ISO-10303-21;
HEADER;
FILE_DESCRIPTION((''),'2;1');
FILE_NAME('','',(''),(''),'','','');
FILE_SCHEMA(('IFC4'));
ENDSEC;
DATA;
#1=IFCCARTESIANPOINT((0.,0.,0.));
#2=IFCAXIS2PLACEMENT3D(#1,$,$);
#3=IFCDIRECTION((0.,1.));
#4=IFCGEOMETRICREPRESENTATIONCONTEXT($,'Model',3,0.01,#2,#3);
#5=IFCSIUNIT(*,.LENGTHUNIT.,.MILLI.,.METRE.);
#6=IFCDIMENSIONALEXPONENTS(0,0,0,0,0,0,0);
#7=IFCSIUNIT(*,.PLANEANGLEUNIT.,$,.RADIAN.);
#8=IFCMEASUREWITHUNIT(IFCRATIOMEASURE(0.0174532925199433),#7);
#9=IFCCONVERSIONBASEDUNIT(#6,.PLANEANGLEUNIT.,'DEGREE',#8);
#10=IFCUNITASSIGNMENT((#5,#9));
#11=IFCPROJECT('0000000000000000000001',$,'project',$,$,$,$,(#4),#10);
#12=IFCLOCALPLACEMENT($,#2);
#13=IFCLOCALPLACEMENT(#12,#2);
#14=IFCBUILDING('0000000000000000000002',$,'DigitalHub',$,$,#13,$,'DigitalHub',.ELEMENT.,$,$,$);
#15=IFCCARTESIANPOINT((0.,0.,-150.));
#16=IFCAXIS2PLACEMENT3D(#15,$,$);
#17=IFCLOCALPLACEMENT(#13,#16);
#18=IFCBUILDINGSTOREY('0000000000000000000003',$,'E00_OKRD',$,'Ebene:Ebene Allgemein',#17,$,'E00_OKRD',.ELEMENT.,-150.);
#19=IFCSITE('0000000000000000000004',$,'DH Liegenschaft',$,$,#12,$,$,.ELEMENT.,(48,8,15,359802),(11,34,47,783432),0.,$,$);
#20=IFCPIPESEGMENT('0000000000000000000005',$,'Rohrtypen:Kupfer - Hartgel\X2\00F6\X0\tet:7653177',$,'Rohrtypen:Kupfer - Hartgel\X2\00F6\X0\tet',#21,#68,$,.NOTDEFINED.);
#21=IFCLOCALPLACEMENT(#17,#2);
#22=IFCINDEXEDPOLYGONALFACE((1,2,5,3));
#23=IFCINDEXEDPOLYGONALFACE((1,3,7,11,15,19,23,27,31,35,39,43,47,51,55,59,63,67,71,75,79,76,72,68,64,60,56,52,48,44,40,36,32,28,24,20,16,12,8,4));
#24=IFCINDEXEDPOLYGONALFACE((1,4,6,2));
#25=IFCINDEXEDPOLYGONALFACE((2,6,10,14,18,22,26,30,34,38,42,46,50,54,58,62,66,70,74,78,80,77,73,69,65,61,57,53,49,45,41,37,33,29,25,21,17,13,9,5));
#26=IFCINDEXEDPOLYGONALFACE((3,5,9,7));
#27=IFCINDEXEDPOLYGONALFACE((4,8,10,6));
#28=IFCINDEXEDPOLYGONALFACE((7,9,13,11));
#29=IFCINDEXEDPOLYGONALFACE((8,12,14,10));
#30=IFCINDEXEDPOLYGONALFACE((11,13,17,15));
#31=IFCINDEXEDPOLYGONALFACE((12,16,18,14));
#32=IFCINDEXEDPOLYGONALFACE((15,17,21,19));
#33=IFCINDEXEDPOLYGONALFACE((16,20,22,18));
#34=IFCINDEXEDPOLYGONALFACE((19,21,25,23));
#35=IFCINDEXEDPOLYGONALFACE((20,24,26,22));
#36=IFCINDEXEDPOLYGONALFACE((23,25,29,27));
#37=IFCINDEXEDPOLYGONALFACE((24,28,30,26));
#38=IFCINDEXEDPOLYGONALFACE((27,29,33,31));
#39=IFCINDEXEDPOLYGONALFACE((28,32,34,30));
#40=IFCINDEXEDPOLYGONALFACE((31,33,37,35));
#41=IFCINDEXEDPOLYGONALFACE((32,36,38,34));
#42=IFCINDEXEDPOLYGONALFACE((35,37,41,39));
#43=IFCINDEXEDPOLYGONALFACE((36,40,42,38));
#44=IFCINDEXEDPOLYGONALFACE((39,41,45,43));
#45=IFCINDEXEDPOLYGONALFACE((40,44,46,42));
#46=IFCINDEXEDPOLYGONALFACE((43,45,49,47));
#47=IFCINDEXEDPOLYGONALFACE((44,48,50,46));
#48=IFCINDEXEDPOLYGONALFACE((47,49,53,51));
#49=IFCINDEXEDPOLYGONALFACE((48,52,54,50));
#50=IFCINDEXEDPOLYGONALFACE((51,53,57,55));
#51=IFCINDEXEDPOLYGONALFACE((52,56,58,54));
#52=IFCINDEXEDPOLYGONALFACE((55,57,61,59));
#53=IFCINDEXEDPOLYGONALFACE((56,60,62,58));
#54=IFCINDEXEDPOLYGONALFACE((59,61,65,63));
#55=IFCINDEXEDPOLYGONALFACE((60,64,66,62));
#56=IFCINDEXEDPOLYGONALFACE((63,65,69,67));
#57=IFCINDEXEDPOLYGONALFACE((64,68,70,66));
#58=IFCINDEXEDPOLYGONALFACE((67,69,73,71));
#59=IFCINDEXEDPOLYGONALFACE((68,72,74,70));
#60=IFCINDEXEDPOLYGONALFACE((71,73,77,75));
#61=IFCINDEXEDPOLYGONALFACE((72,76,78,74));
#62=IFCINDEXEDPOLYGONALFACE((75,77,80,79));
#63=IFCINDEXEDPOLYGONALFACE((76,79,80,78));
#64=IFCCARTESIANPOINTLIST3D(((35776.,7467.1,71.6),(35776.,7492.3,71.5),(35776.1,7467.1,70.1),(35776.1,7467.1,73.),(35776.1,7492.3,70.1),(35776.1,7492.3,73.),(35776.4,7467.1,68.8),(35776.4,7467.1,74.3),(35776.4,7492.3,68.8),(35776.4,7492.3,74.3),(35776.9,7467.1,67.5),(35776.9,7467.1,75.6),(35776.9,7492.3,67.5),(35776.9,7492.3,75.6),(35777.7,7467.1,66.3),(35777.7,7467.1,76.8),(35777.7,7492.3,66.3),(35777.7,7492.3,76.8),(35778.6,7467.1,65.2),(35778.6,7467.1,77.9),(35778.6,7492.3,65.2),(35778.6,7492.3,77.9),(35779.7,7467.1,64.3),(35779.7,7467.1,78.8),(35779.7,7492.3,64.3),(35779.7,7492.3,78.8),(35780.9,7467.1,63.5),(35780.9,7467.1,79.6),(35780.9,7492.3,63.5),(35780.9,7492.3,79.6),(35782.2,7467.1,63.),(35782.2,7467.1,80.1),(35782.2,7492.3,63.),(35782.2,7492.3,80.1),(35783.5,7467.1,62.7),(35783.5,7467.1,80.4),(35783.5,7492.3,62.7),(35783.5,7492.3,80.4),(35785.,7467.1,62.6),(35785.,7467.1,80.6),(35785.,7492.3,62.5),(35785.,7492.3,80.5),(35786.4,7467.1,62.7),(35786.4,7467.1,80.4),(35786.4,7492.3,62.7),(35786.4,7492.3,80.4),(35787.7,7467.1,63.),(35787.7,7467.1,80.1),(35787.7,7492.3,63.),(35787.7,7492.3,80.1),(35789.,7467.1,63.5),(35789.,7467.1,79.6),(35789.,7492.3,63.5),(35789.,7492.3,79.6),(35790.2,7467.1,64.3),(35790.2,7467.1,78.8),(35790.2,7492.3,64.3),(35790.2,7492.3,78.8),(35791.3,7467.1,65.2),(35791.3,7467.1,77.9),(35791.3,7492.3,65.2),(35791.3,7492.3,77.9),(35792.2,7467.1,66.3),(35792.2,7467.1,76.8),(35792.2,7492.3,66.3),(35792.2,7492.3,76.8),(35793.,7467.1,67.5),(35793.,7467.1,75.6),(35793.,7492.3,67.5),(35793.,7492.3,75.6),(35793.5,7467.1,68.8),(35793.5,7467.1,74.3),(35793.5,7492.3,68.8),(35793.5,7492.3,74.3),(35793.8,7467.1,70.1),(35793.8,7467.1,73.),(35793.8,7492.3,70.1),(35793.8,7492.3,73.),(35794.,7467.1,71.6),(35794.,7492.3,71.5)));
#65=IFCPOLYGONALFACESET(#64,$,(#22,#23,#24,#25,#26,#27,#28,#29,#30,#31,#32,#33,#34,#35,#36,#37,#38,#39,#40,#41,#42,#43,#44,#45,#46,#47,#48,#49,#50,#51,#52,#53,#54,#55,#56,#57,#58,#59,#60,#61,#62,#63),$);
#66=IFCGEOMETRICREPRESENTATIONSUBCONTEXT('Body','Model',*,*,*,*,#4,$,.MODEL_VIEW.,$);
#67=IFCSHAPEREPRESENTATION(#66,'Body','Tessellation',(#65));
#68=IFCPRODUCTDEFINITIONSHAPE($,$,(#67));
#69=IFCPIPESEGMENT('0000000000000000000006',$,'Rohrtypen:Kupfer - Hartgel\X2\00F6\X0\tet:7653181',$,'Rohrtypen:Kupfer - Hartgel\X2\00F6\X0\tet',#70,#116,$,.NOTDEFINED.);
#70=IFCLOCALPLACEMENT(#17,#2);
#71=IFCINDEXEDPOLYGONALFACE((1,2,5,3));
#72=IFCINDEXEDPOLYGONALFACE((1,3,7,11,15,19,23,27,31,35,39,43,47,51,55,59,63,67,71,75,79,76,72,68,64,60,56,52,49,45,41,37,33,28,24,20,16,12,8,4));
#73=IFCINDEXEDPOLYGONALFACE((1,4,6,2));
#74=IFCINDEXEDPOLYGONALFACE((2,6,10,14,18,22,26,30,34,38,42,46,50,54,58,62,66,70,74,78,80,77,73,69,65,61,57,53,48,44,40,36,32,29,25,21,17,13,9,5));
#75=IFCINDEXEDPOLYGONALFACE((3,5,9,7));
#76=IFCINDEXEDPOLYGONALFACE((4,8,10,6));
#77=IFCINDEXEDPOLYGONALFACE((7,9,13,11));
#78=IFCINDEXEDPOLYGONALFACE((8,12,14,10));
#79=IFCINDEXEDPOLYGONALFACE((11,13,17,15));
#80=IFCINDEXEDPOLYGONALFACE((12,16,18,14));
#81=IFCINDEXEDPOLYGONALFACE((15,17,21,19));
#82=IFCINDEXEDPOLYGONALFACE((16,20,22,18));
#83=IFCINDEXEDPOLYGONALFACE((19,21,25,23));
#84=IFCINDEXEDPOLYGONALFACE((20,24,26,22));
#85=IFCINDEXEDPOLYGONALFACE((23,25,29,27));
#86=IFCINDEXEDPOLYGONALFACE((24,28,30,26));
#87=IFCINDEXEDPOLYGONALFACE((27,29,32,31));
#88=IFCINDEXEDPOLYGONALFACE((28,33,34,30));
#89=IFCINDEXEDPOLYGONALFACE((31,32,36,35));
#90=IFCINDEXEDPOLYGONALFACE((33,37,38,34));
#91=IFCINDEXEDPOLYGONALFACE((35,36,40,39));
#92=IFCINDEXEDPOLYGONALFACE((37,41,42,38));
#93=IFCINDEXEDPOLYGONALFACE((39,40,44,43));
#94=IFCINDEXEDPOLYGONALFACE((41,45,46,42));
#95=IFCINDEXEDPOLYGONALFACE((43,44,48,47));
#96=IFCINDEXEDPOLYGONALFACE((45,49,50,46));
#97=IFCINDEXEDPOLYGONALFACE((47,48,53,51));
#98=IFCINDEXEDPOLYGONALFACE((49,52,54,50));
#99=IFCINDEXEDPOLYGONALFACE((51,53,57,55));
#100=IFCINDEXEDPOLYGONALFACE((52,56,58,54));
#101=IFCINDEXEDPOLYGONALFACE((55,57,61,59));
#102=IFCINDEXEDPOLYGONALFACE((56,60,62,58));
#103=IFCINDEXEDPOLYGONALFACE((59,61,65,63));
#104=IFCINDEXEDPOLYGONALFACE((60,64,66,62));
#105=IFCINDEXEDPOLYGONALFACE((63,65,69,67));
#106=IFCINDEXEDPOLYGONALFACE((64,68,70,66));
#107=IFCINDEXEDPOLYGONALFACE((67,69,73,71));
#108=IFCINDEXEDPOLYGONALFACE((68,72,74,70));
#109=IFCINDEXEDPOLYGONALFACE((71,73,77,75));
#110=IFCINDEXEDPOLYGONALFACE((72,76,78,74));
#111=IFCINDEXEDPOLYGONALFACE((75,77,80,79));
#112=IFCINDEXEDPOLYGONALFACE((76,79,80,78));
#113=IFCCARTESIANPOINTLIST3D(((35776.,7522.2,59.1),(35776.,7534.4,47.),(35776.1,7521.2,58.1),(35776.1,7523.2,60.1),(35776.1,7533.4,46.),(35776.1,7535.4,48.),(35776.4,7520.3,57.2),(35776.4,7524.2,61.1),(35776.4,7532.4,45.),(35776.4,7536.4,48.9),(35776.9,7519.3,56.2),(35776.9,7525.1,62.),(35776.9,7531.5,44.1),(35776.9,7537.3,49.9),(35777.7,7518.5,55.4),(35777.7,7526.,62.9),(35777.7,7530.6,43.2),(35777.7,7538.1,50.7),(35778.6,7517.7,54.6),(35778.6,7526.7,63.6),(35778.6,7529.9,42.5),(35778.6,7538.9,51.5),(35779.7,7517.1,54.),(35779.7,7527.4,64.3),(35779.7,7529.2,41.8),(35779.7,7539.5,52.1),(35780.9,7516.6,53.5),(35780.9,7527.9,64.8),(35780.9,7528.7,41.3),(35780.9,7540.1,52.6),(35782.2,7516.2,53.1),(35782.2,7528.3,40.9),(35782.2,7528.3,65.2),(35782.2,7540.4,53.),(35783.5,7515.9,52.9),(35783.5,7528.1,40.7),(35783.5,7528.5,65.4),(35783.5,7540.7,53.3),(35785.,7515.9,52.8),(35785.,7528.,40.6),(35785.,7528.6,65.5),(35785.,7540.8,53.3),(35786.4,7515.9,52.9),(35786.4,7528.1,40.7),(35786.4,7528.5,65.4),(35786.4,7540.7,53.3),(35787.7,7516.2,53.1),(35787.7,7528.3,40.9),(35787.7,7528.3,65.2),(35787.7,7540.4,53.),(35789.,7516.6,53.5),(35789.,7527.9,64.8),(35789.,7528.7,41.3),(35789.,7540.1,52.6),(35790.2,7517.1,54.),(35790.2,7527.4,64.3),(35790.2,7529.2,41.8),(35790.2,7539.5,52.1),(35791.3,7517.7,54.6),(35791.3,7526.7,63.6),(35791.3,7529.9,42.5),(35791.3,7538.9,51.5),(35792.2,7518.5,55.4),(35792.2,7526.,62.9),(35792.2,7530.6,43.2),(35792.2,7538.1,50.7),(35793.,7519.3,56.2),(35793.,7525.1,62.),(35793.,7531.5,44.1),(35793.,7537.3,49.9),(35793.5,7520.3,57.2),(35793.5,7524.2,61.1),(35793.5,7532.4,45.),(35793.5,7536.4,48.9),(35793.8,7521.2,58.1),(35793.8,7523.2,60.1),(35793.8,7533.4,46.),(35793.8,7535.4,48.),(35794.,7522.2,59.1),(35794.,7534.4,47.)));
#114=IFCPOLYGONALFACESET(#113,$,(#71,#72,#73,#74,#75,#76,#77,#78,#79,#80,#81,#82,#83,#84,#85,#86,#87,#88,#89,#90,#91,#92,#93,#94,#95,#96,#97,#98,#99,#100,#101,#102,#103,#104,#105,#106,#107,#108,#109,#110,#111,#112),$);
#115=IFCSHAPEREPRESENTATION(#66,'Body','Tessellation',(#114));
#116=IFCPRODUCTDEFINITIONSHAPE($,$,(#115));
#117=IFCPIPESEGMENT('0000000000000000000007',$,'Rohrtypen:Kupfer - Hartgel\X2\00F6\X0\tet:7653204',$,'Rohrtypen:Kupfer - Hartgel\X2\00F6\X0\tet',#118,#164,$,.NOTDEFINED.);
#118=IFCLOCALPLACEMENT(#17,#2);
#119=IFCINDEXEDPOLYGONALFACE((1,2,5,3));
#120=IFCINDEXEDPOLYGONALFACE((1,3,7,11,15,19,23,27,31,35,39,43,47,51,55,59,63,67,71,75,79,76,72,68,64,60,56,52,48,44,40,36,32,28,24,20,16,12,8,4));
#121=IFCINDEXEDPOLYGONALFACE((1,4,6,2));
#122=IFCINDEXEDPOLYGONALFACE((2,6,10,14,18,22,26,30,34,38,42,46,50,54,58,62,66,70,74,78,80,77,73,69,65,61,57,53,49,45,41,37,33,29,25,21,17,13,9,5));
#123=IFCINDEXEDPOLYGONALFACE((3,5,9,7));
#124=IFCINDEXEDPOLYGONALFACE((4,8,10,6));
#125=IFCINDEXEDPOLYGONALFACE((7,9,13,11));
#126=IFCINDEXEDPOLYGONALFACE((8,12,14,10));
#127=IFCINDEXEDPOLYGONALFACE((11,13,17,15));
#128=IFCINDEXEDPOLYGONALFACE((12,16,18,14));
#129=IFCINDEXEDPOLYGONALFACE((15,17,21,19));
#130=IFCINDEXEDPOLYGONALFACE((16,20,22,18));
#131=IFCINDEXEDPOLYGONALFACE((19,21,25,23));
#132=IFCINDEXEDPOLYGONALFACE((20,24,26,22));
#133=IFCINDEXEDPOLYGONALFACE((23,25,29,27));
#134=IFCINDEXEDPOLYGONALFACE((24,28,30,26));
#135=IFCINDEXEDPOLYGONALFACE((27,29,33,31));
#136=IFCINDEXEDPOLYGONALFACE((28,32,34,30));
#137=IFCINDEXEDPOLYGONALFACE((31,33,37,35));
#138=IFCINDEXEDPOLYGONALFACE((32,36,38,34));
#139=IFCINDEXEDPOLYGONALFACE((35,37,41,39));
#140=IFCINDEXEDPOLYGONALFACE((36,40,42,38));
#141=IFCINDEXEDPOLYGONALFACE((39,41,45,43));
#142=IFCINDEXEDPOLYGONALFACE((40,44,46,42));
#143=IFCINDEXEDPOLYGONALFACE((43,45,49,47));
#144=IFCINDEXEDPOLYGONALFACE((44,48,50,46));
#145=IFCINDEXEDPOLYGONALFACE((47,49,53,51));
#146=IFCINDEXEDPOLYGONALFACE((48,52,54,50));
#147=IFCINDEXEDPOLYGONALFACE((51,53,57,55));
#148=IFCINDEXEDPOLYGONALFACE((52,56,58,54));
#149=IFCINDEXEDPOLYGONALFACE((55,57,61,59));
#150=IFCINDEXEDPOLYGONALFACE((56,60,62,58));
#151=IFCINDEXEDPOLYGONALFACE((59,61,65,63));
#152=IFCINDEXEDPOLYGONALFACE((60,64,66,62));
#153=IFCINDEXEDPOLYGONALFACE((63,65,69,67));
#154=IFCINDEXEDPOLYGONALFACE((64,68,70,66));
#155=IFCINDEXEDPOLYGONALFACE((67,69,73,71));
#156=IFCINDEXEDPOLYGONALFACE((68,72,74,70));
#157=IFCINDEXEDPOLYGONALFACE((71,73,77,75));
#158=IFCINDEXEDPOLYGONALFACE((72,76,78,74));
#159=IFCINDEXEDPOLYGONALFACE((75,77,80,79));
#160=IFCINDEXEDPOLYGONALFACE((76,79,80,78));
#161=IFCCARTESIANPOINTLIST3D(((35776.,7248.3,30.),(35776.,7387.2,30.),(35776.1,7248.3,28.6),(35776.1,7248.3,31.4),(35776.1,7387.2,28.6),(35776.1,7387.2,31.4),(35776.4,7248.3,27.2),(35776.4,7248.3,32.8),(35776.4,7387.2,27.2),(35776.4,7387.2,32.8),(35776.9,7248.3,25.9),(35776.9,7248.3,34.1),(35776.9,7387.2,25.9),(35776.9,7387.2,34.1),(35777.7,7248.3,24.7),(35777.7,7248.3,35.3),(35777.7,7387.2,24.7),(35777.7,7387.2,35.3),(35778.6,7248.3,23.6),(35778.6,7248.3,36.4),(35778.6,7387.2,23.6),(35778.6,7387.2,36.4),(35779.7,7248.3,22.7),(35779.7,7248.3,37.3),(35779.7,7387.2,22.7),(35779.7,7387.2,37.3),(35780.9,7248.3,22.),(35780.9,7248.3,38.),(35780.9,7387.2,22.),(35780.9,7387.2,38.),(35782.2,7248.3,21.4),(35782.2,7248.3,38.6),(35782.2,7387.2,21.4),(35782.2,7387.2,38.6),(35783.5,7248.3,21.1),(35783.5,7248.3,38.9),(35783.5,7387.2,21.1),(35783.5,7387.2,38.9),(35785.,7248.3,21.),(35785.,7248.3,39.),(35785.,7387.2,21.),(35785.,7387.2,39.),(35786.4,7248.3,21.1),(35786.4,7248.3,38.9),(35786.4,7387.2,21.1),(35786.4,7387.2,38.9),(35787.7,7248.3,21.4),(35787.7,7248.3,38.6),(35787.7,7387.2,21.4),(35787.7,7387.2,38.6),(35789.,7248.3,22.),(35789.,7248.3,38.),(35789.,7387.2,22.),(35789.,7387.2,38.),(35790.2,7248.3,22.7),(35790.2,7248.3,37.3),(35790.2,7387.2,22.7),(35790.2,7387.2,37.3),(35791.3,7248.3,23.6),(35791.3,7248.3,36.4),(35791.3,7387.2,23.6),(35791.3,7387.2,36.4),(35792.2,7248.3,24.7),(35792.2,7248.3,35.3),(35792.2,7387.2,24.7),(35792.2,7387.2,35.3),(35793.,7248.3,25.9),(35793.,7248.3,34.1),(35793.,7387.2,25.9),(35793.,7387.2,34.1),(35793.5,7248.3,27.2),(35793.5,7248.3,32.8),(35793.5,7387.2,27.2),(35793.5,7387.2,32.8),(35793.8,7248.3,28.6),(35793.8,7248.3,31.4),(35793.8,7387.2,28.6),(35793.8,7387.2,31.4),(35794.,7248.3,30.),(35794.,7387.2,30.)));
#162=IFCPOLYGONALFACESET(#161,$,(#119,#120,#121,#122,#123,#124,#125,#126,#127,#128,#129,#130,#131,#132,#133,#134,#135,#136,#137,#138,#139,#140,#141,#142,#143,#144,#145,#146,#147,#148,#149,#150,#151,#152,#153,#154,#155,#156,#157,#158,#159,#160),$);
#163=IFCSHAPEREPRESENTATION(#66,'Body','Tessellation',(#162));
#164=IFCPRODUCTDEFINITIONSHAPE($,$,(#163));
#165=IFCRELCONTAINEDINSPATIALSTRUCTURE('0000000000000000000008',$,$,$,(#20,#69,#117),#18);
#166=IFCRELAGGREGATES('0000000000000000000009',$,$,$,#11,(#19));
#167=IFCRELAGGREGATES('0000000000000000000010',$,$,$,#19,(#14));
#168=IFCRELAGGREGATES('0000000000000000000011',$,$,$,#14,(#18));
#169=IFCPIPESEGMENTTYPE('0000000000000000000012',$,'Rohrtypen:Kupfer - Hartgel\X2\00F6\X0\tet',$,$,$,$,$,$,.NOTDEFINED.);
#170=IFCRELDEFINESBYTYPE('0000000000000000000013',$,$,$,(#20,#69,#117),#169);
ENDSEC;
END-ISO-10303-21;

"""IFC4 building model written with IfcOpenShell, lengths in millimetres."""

from ifc_helpers import new_model, entity, si_unit, converted_unit, direction, frame, origin, place, context, subcontext, project, spatial, indexed_curve, outline, extrude, type_object, element, save


model = new_model("IFC4")

# Units and contexts
model_context = context("Model", 3, precision=0.01, world=origin(), true_north=direction((0.0, 1.0)))
body_context = subcontext(model_context, "Body", "Model", "MODEL_VIEW")
ifc_project = project(units=[si_unit("LENGTHUNIT", "METRE", prefix="MILLI"), converted_unit("PLANEANGLEUNIT", "DEGREE", entity("IfcRatioMeasure", 0.0174532925199433), si_unit("PLANEANGLEUNIT", "RADIAN"), dimensions=[0, 0, 0, 0, 0, 0, 0])], contexts=[model_context])

# Site, building, storey
site_placement = place(None, origin())
site = spatial("IfcSite", under=ifc_project, at=site_placement, Name="DH Liegenschaft", CompositionType="ELEMENT", RefLatitude=(48, 8, 15, 359802), RefLongitude=(11, 34, 47, 783432), RefElevation=0.0)
building_placement = place(site_placement, origin())
building = spatial("IfcBuilding", under=site, at=building_placement, Name="DigitalHub", LongName="DigitalHub", CompositionType="ELEMENT")
storey_placement = place(building_placement, frame((0.0, 0.0, -150.0)))
storey = spatial("IfcBuildingStorey", under=building, at=storey_placement, Name="E00_OKRD", ObjectType="Ebene:Ebene Allgemein", LongName="E00_OKRD", CompositionType="ELEMENT", Elevation=-150.0)

# Pipe segments
pipe_segment_type = type_object("IfcPipeSegmentType", Name="Rohrtypen:Kupfer - Hartgelötet", PredefinedType="NOTDEFINED")
pipe_segment_1_placement = place(storey_placement, frame((35774.4, 7467.1, 61.0)))
element("IfcPipeSegment", 1, at=pipe_segment_1_placement, inside=storey, type_object=pipe_segment_type, Name="Rohrtypen:Kupfer - Hartgelötet:7653177", ObjectType="Rohrtypen:Kupfer - Hartgelötet", PredefinedType="NOTDEFINED", context=body_context, shape_type="SweptSolid", body=[
    extrude(outline(indexed_curve([(9.0, 0.0), (8.9, 1.4), (8.6, 2.8), (8.0, 4.1), (7.3, 5.3), (6.4, 6.4), (5.3, 7.3), (4.1, 8.0), (2.8, 8.6), (1.4, 8.9), (0.0, 9.0), (-1.4, 8.9), (-2.8, 8.6), (-4.1, 8.0), (-5.3, 7.3), (-6.4, 6.4), (-7.3, 5.3), (-8.0, 4.1), (-8.6, 2.8), (-8.9, 1.4), (-9.0, 0.0), (-8.9, -1.4), (-8.6, -2.8), (-8.0, -4.1), (-7.3, -5.3), (-6.4, -6.4), (-5.3, -7.3), (-4.1, -8.0), (-2.8, -8.6), (-1.4, -8.9), (0.0, -9.0), (1.4, -8.9), (2.8, -8.6), (4.1, -8.0), (5.3, -7.3), (6.4, -6.4), (7.3, -5.3), (8.0, -4.1), (8.6, -2.8), (8.9, -1.4), (9.0, 0.0)], self_intersect=False)), frame((10.6, 0.0, 10.6), z_axis=(0.000069, 1.0, -0.000282), x_axis=(-1.0, 0.000069, 0.0)), (0.0, 0.0, 1.0), 25.1),
])
pipe_segment_2_placement = place(storey_placement, frame((35774.4, 7514.3, 39.0)))
element("IfcPipeSegment", 2, at=pipe_segment_2_placement, inside=storey, type_object=pipe_segment_type, Name="Rohrtypen:Kupfer - Hartgelötet:7653181", ObjectType="Rohrtypen:Kupfer - Hartgelötet", PredefinedType="NOTDEFINED", context=body_context, shape_type="SweptSolid", body=[
    extrude(outline(indexed_curve([(9.0, 0.0), (8.9, 1.4), (8.6, 2.8), (8.0, 4.1), (7.3, 5.3), (6.4, 6.4), (5.3, 7.3), (4.1, 8.0), (2.8, 8.6), (1.4, 8.9), (0.0, 9.0), (-1.4, 8.9), (-2.8, 8.6), (-4.1, 8.0), (-5.3, 7.3), (-6.4, 6.4), (-7.3, 5.3), (-8.0, 4.1), (-8.6, 2.8), (-8.9, 1.4), (-9.0, 0.0), (-8.9, -1.4), (-8.6, -2.8), (-8.0, -4.1), (-7.3, -5.3), (-6.4, -6.4), (-5.3, -7.3), (-4.1, -8.0), (-2.8, -8.6), (-1.4, -8.9), (0.0, -9.0), (1.4, -8.9), (2.8, -8.6), (4.1, -8.0), (5.3, -7.3), (6.4, -6.4), (7.3, -5.3), (8.0, -4.1), (8.6, -2.8), (8.9, -1.4), (9.0, 0.0)], self_intersect=False)), frame((10.6, 8.0, 20.1), z_axis=(0.000009, 0.707107, -0.707107), x_axis=(1.0, -0.000013, 0.0)), (0.0, 0.0, 1.0), 17.2),
])
pipe_segment_3_placement = place(storey_placement, frame((35774.4, 7248.3, 19.4)))
element("IfcPipeSegment", 3, at=pipe_segment_3_placement, inside=storey, type_object=pipe_segment_type, Name="Rohrtypen:Kupfer - Hartgelötet:7653204", ObjectType="Rohrtypen:Kupfer - Hartgelötet", PredefinedType="NOTDEFINED", context=body_context, shape_type="SweptSolid", body=[
    extrude(outline(indexed_curve([(9.0, 0.0), (8.9, 1.4), (8.6, 2.8), (8.0, 4.1), (7.3, 5.3), (6.4, 6.4), (5.3, 7.3), (4.1, 8.0), (2.8, 8.6), (1.4, 8.9), (0.0, 9.0), (-1.4, 8.9), (-2.8, 8.6), (-4.1, 8.0), (-5.3, 7.3), (-6.4, 6.4), (-7.3, 5.3), (-8.0, 4.1), (-8.6, 2.8), (-8.9, 1.4), (-9.0, 0.0), (-8.9, -1.4), (-8.6, -2.8), (-8.0, -4.1), (-7.3, -5.3), (-6.4, -6.4), (-5.3, -7.3), (-4.1, -8.0), (-2.8, -8.6), (-1.4, -8.9), (0.0, -9.0), (1.4, -8.9), (2.8, -8.6), (4.1, -8.0), (5.3, -7.3), (6.4, -6.4), (7.3, -5.3), (8.0, -4.1), (8.6, -2.8), (8.9, -1.4), (9.0, 0.0)], self_intersect=False)), frame((10.6, 0.0, 10.6), z_axis=(0.0, 1.0, 0.0), x_axis=(-1.0, 0.0, 0.0)), (0.0, 0.0, 1.0), 138.8),
])

save(model, "model.ifc")
